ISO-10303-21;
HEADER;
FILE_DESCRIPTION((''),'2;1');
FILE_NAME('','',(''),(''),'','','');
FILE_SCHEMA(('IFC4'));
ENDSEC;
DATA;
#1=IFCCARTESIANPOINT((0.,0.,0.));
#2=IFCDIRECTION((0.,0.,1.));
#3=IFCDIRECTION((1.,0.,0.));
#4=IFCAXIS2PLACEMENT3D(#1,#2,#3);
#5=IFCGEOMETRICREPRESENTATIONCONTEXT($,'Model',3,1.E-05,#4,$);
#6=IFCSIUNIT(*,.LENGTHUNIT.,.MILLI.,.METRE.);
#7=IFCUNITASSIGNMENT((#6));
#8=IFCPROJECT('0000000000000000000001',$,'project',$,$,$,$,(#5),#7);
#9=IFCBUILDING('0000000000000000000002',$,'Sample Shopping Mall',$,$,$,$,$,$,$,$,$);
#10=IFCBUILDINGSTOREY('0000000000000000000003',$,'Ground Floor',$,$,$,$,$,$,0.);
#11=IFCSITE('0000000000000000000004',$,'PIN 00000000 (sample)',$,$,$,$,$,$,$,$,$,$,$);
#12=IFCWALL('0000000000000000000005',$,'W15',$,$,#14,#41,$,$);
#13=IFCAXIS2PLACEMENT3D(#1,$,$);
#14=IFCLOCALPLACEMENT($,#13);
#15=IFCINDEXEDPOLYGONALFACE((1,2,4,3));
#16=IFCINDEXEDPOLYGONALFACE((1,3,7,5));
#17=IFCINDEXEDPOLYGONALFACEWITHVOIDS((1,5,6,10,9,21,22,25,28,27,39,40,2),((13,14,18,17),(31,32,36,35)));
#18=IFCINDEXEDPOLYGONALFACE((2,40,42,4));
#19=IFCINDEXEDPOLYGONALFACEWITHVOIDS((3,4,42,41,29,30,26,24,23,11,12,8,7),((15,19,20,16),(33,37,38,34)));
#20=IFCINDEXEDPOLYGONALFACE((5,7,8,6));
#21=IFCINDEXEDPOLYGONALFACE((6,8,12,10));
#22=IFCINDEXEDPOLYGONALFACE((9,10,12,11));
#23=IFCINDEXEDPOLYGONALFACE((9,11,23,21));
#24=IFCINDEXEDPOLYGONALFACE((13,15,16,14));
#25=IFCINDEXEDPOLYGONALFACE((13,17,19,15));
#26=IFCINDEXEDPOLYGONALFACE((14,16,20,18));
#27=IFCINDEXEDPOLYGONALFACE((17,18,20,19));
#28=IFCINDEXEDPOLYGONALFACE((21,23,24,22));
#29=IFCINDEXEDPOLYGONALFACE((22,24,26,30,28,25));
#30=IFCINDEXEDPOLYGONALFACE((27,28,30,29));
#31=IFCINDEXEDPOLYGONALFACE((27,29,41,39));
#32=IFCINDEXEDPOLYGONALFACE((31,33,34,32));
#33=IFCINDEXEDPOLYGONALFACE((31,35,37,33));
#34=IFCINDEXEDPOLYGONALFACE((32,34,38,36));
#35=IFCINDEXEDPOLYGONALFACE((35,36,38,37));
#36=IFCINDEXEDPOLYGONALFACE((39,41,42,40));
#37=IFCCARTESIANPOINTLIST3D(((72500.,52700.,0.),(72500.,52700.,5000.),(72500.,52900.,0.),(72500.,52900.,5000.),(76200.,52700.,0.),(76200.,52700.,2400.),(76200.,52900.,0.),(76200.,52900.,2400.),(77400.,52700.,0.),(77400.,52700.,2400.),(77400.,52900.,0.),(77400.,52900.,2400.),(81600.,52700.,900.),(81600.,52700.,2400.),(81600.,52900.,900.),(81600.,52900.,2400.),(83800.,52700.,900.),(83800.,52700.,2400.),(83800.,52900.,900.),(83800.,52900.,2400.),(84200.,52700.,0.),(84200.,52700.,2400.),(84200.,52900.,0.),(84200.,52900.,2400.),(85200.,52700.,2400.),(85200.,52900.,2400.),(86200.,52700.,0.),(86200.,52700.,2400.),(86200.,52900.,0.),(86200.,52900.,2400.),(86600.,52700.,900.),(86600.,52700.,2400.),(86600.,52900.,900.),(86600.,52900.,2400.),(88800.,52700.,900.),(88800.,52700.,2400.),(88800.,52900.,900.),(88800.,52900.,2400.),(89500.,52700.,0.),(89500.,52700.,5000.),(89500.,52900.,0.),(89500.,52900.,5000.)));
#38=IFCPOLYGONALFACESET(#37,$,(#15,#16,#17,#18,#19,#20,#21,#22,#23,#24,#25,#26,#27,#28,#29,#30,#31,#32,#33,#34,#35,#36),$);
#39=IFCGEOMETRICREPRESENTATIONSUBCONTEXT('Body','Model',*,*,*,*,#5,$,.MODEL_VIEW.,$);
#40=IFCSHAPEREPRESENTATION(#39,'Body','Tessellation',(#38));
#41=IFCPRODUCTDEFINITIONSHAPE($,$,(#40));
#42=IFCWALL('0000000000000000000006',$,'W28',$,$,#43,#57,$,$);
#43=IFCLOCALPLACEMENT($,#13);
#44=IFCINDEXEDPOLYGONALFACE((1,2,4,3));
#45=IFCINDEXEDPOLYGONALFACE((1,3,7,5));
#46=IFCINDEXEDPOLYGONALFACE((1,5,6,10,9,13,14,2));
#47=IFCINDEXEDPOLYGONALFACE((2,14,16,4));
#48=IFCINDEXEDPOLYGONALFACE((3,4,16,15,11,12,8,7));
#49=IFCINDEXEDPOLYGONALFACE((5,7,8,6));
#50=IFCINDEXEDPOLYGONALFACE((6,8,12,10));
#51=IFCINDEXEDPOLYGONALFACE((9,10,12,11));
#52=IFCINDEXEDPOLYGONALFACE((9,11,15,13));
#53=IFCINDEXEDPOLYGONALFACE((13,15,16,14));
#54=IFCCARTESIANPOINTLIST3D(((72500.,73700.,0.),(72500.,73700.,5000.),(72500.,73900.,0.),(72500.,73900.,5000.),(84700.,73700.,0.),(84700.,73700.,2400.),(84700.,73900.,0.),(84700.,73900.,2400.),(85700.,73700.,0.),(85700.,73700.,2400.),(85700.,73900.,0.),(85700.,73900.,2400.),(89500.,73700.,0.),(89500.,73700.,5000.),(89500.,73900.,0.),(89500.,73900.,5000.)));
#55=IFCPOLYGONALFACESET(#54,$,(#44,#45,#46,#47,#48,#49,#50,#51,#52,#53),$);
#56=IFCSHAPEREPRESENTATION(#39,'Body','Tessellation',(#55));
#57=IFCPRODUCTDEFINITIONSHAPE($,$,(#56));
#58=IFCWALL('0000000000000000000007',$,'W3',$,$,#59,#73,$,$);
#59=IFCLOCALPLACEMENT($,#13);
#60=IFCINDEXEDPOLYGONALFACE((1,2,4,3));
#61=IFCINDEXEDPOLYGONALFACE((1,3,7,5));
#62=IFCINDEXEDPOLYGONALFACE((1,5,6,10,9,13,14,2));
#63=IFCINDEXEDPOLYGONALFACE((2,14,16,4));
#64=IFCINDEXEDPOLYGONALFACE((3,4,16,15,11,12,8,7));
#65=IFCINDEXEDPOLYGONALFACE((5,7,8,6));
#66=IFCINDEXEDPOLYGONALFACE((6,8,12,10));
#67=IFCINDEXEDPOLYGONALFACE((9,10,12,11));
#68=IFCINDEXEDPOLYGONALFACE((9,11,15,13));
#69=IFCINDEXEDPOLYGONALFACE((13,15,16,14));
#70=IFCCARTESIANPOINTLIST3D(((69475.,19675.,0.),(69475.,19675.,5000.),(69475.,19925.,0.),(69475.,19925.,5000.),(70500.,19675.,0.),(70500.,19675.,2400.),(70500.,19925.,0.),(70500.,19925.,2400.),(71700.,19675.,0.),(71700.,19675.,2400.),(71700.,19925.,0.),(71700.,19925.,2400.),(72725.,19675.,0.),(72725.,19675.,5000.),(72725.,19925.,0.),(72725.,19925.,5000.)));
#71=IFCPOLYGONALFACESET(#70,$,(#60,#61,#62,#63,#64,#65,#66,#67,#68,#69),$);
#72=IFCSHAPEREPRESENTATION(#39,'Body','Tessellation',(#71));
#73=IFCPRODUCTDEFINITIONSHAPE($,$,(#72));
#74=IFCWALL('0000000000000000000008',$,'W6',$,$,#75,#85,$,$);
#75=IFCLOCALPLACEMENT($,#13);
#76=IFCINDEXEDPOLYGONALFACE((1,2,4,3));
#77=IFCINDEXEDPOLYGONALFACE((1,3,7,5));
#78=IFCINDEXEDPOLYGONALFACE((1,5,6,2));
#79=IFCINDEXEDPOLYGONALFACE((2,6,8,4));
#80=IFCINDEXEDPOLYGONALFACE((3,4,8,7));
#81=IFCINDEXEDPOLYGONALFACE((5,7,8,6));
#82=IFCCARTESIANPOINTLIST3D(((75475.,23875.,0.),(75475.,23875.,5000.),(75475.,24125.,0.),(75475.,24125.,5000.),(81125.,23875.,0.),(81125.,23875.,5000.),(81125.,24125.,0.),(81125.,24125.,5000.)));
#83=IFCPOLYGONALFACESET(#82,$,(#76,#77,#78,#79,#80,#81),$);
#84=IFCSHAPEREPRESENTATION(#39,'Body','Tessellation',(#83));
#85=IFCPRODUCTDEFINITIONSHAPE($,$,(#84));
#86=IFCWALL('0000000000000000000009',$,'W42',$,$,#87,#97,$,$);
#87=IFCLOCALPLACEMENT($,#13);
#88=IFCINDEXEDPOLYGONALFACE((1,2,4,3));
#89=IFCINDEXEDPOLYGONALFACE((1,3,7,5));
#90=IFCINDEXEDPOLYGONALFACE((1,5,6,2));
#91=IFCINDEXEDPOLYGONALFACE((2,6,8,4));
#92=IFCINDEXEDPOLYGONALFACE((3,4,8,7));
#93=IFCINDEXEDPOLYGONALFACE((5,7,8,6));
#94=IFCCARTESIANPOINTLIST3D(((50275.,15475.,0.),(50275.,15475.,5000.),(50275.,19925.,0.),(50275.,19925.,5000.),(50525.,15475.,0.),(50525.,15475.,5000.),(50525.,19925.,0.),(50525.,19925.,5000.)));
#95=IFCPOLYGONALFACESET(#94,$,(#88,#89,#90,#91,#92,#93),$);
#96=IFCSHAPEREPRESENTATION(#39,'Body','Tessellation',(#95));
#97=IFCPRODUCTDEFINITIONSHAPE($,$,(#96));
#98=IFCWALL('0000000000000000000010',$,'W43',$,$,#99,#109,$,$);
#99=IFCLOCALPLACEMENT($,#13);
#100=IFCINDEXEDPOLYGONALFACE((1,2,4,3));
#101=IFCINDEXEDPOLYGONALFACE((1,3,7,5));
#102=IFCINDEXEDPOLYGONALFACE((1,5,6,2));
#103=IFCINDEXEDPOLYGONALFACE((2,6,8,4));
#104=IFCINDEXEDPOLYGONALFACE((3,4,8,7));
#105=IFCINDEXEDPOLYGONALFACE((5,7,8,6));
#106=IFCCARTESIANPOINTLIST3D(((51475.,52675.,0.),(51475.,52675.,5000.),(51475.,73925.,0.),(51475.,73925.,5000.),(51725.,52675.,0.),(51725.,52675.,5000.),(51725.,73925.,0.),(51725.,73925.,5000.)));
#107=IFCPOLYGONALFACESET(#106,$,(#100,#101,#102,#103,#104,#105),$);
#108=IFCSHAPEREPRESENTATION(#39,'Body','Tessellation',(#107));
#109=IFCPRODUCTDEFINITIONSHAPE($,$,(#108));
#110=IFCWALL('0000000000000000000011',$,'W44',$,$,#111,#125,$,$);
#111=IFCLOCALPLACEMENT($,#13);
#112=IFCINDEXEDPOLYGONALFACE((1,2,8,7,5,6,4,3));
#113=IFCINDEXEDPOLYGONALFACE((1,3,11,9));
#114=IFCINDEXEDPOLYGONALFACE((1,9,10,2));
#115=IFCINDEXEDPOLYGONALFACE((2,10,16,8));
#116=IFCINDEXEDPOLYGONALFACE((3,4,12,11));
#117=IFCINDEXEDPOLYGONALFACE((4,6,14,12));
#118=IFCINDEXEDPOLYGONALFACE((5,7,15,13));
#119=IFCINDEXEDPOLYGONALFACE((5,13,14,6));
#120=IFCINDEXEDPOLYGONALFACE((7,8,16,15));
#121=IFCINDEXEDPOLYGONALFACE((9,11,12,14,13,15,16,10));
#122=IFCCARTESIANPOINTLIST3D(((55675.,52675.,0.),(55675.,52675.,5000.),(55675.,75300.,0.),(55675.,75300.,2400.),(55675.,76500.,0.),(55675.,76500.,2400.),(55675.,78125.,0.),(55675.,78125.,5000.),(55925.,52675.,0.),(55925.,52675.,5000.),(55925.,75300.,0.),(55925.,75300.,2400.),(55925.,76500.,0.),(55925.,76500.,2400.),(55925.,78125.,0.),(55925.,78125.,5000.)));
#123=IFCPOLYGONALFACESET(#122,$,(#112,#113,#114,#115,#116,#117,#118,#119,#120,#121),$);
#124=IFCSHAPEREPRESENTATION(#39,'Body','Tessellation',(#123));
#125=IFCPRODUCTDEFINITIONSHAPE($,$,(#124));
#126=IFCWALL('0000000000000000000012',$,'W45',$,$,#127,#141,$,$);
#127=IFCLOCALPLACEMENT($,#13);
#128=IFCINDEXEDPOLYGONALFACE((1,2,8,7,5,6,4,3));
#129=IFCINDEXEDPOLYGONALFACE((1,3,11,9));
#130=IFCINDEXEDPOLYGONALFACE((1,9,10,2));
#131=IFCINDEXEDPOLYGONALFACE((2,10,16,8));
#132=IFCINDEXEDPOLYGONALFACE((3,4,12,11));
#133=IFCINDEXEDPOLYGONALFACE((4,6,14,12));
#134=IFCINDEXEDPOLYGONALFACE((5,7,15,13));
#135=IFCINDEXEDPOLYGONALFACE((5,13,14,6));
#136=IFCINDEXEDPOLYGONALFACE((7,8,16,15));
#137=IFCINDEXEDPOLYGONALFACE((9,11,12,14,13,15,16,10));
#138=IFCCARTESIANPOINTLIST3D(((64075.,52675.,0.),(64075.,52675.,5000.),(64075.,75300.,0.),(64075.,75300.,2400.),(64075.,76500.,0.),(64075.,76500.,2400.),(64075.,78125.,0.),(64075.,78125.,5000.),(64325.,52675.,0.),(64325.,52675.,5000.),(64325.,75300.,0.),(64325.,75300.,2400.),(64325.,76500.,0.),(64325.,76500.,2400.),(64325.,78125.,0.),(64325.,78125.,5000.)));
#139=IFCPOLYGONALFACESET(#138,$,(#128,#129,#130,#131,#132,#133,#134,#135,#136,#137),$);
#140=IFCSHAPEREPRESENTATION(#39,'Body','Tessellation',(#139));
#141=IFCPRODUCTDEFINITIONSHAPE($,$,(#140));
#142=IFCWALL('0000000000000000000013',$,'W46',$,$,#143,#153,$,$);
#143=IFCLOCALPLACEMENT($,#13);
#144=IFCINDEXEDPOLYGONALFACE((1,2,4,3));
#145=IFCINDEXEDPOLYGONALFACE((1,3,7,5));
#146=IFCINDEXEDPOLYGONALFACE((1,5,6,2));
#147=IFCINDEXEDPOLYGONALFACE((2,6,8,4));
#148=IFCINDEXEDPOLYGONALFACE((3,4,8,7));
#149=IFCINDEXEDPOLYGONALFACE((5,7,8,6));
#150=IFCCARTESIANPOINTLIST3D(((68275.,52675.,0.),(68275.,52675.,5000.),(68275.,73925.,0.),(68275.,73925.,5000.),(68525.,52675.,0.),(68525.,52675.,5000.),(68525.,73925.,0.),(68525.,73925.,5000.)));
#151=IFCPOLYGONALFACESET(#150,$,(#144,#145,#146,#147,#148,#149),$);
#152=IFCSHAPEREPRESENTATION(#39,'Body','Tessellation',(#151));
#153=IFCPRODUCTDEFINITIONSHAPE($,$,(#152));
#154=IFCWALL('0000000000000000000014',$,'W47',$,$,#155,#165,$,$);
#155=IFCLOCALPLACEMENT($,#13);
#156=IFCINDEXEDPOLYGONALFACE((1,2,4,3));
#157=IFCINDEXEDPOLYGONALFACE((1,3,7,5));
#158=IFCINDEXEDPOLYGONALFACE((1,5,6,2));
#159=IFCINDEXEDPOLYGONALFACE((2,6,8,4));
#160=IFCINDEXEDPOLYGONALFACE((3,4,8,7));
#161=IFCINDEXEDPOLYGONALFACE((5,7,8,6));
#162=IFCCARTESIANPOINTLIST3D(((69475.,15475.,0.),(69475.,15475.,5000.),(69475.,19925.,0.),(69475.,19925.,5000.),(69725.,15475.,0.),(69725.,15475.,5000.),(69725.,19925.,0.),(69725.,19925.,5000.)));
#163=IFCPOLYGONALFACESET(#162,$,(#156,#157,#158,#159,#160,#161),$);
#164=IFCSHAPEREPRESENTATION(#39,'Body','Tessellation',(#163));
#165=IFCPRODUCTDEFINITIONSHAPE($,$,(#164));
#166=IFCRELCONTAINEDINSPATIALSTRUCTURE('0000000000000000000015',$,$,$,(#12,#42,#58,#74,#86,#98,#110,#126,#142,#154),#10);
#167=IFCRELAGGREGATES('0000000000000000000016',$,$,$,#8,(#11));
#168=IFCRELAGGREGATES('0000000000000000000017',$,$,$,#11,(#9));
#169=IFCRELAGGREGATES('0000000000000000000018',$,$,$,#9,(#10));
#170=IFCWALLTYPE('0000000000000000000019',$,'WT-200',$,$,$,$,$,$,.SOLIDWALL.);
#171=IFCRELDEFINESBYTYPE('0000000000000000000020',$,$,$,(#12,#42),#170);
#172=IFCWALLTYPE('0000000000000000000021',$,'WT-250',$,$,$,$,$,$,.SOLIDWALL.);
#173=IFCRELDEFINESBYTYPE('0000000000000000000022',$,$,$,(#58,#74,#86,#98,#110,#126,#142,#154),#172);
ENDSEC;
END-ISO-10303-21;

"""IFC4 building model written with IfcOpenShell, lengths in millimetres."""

from ifc_helpers import new_model, si_unit, frame, origin_with_axes, place, context, subcontext, project, spatial, indexed_curve, outline, extrude, type_object, element, save


model = new_model("IFC4")

# Units and contexts
model_context = context("Model", 3, precision=1e-05, world=origin_with_axes())
body_context = subcontext(model_context, "Body", "Model", "MODEL_VIEW")
ifc_project = project(units=[si_unit("LENGTHUNIT", "METRE", prefix="MILLI")], contexts=[model_context])

# Site, building, storey
site = spatial("IfcSite", under=ifc_project, Name="PIN 00000000 (sample)")
building = spatial("IfcBuilding", under=site, Name="Sample Shopping Mall")
storey = spatial("IfcBuildingStorey", under=building, Name="Ground Floor", Elevation=0.0)

# Wall, openings
wall_type_1 = type_object("IfcWallType", Name="WT-200", PredefinedType="SOLIDWALL")
wall_1_placement = place(None, frame((72500.0, 52700.0, 0.0), z_axis=(0.0, 0.0, 1.0), x_axis=(1.0, 0.0, 0.0)))
wall_1 = element("IfcWall", 1, at=wall_1_placement, inside=storey, type_object=wall_type_1, Name="W15", context=body_context, shape_type="SweptSolid", body=[
    extrude(outline(indexed_curve([(0.0, 0.0), (0.0, 200.0), (17000.0, 200.0), (17000.0, 0.0), (0.0, 0.0)], self_intersect=False)), origin_with_axes(), (0.0, 0.0, 1.0), 5000.0),
])
opening_1_placement = place(wall_1_placement, frame((3700.0, -100.0, 0.0), z_axis=(0.0, 0.0, 1.0), x_axis=(1.0, 0.0, 0.0)))
element("IfcOpeningElement", 2, at=opening_1_placement, cuts=wall_1, context=body_context, shape_type="SweptSolid", body=[
    extrude(outline(indexed_curve([(0.0, 0.0), (0.0, 400.0), (1200.0, 400.0), (1200.0, 0.0), (0.0, 0.0)], self_intersect=False)), origin_with_axes(), (0.0, 0.0, 1.0), 2400.0),
])
opening_2_placement = place(wall_1_placement, frame((11700.0, -100.0, 0.0), z_axis=(0.0, 0.0, 1.0), x_axis=(1.0, 0.0, 0.0)))
element("IfcOpeningElement", 3, at=opening_2_placement, cuts=wall_1, context=body_context, shape_type="SweptSolid", body=[
    extrude(outline(indexed_curve([(0.0, 0.0), (0.0, 400.0), (1000.0, 400.0), (1000.0, 0.0), (0.0, 0.0)], self_intersect=False)), origin_with_axes(), (0.0, 0.0, 1.0), 2400.0),
])
opening_3_placement = place(wall_1_placement, frame((12700.0, -100.0, 0.0), z_axis=(0.0, 0.0, 1.0), x_axis=(1.0, 0.0, 0.0)))
element("IfcOpeningElement", 4, at=opening_3_placement, cuts=wall_1, context=body_context, shape_type="SweptSolid", body=[
    extrude(outline(indexed_curve([(0.0, 0.0), (0.0, 400.0), (1000.0, 400.0), (1000.0, 0.0), (0.0, 0.0)], self_intersect=False)), origin_with_axes(), (0.0, 0.0, 1.0), 2400.0),
])
opening_4_placement = place(wall_1_placement, frame((9100.0, -100.0, 900.0), z_axis=(0.0, 0.0, 1.0), x_axis=(1.0, 0.0, 0.0)))
element("IfcOpeningElement", 5, at=opening_4_placement, cuts=wall_1, context=body_context, shape_type="SweptSolid", body=[
    extrude(outline(indexed_curve([(0.0, 0.0), (0.0, 400.0), (2200.0, 400.0), (2200.0, 0.0), (0.0, 0.0)], self_intersect=False)), origin_with_axes(), (0.0, 0.0, 1.0), 1500.0),
])
opening_5_placement = place(wall_1_placement, frame((14100.0, -100.0, 900.0), z_axis=(0.0, 0.0, 1.0), x_axis=(1.0, 0.0, 0.0)))
element("IfcOpeningElement", 6, at=opening_5_placement, cuts=wall_1, context=body_context, shape_type="SweptSolid", body=[
    extrude(outline(indexed_curve([(0.0, 0.0), (0.0, 400.0), (2200.0, 400.0), (2200.0, 0.0), (0.0, 0.0)], self_intersect=False)), origin_with_axes(), (0.0, 0.0, 1.0), 1500.0),
])

# Walls, openings
wall_2_placement = place(None, frame((72500.0, 73700.0, 0.0), z_axis=(0.0, 0.0, 1.0), x_axis=(1.0, 0.0, 0.0)))
wall_2 = element("IfcWall", 7, at=wall_2_placement, inside=storey, type_object=wall_type_1, Name="W28", context=body_context, shape_type="SweptSolid", body=[
    extrude(outline(indexed_curve([(0.0, 0.0), (0.0, 200.0), (17000.0, 200.0), (17000.0, 0.0), (0.0, 0.0)], self_intersect=False)), origin_with_axes(), (0.0, 0.0, 1.0), 5000.0),
])
opening_6_placement = place(wall_2_placement, frame((12200.0, -100.0, 0.0), z_axis=(0.0, 0.0, 1.0), x_axis=(1.0, 0.0, 0.0)))
element("IfcOpeningElement", 8, at=opening_6_placement, cuts=wall_2, context=body_context, shape_type="SweptSolid", body=[
    extrude(outline(indexed_curve([(0.0, 0.0), (0.0, 400.0), (1000.0, 400.0), (1000.0, 0.0), (0.0, 0.0)], self_intersect=False)), origin_with_axes(), (0.0, 0.0, 1.0), 2400.0),
])
wall_type_2 = type_object("IfcWallType", Name="WT-250", PredefinedType="SOLIDWALL")
wall_3_placement = place(None, frame((69475.0, 19675.0, 0.0), z_axis=(0.0, 0.0, 1.0), x_axis=(1.0, 0.0, 0.0)))
wall_3 = element("IfcWall", 9, at=wall_3_placement, inside=storey, type_object=wall_type_2, Name="W3", context=body_context, shape_type="SweptSolid", body=[
    extrude(outline(indexed_curve([(0.0, 0.0), (0.0, 250.0), (3250.0, 250.0), (3250.0, 0.0), (0.0, 0.0)], self_intersect=False)), origin_with_axes(), (0.0, 0.0, 1.0), 5000.0),
])
opening_7_placement = place(wall_3_placement, frame((1025.0, -100.0, 0.0), z_axis=(0.0, 0.0, 1.0), x_axis=(1.0, 0.0, 0.0)))
element("IfcOpeningElement", 10, at=opening_7_placement, cuts=wall_3, context=body_context, shape_type="SweptSolid", body=[
    extrude(outline(indexed_curve([(0.0, 0.0), (0.0, 450.0), (1200.0, 450.0), (1200.0, 0.0), (0.0, 0.0)], self_intersect=False)), origin_with_axes(), (0.0, 0.0, 1.0), 2400.0),
])

# Wall
wall_4_placement = place(None, frame((75475.0, 23875.0, 0.0), z_axis=(0.0, 0.0, 1.0), x_axis=(1.0, 0.0, 0.0)))
element("IfcWall", 11, at=wall_4_placement, inside=storey, type_object=wall_type_2, Name="W6", context=body_context, shape_type="SweptSolid", body=[
    extrude(outline(indexed_curve([(0.0, 0.0), (0.0, 250.0), (5650.0, 250.0), (5650.0, 0.0), (0.0, 0.0)], self_intersect=False)), origin_with_axes(), (0.0, 0.0, 1.0), 5000.0),
])

# Walls
wall_5_placement = place(None, frame((50525.0, 15475.0, 0.0), z_axis=(0.0, 0.0, 1.0), x_axis=(0.0, 1.0, 0.0)))
element("IfcWall", 12, at=wall_5_placement, inside=storey, type_object=wall_type_2, Name="W42", context=body_context, shape_type="SweptSolid", body=[
    extrude(outline(indexed_curve([(0.0, 0.0), (0.0, 250.0), (4450.0, 250.0), (4450.0, 0.0), (0.0, 0.0)], self_intersect=False)), origin_with_axes(), (0.0, 0.0, 1.0), 5000.0),
])
wall_6_placement = place(None, frame((51725.0, 52675.0, 0.0), z_axis=(0.0, 0.0, 1.0), x_axis=(0.0, 1.0, 0.0)))
element("IfcWall", 13, at=wall_6_placement, inside=storey, type_object=wall_type_2, Name="W43", context=body_context, shape_type="SweptSolid", body=[
    extrude(outline(indexed_curve([(0.0, 0.0), (0.0, 250.0), (21250.0, 250.0), (21250.0, 0.0), (0.0, 0.0)], self_intersect=False)), origin_with_axes(), (0.0, 0.0, 1.0), 5000.0),
])

# Walls, openings
wall_7_placement = place(None, frame((55925.0, 52675.0, 0.0), z_axis=(0.0, 0.0, 1.0), x_axis=(0.0, 1.0, 0.0)))
wall_7 = element("IfcWall", 14, at=wall_7_placement, inside=storey, type_object=wall_type_2, Name="W44", context=body_context, shape_type="SweptSolid", body=[
    extrude(outline(indexed_curve([(0.0, 0.0), (0.0, 250.0), (25450.0, 250.0), (25450.0, 0.0), (0.0, 0.0)], self_intersect=False)), origin_with_axes(), (0.0, 0.0, 1.0), 5000.0),
])
opening_8_placement = place(wall_7_placement, frame((22625.0, -100.0, 0.0), z_axis=(0.0, 0.0, 1.0), x_axis=(1.0, 0.0, 0.0)))
element("IfcOpeningElement", 15, at=opening_8_placement, cuts=wall_7, context=body_context, shape_type="SweptSolid", body=[
    extrude(outline(indexed_curve([(0.0, 0.0), (0.0, 450.0), (1200.0, 450.0), (1200.0, 0.0), (0.0, 0.0)], self_intersect=False)), origin_with_axes(), (0.0, 0.0, 1.0), 2400.0),
])
wall_8_placement = place(None, frame((64325.0, 52675.0, 0.0), z_axis=(0.0, 0.0, 1.0), x_axis=(0.0, 1.0, 0.0)))
wall_8 = element("IfcWall", 16, at=wall_8_placement, inside=storey, type_object=wall_type_2, Name="W45", context=body_context, shape_type="SweptSolid", body=[
    extrude(outline(indexed_curve([(0.0, 0.0), (0.0, 250.0), (25450.0, 250.0), (25450.0, 0.0), (0.0, 0.0)], self_intersect=False)), origin_with_axes(), (0.0, 0.0, 1.0), 5000.0),
])
opening_9_placement = place(wall_8_placement, frame((22625.0, -100.0, 0.0), z_axis=(0.0, 0.0, 1.0), x_axis=(1.0, 0.0, 0.0)))
element("IfcOpeningElement", 17, at=opening_9_placement, cuts=wall_8, context=body_context, shape_type="SweptSolid", body=[
    extrude(outline(indexed_curve([(0.0, 0.0), (0.0, 450.0), (1200.0, 450.0), (1200.0, 0.0), (0.0, 0.0)], self_intersect=False)), origin_with_axes(), (0.0, 0.0, 1.0), 2400.0),
])

# Walls
wall_9_placement = place(None, frame((68525.0, 52675.0, 0.0), z_axis=(0.0, 0.0, 1.0), x_axis=(0.0, 1.0, 0.0)))
element("IfcWall", 18, at=wall_9_placement, inside=storey, type_object=wall_type_2, Name="W46", context=body_context, shape_type="SweptSolid", body=[
    extrude(outline(indexed_curve([(0.0, 0.0), (0.0, 250.0), (21250.0, 250.0), (21250.0, 0.0), (0.0, 0.0)], self_intersect=False)), origin_with_axes(), (0.0, 0.0, 1.0), 5000.0),
])
wall_10_placement = place(None, frame((69725.0, 15475.0, 0.0), z_axis=(0.0, 0.0, 1.0), x_axis=(0.0, 1.0, 0.0)))
element("IfcWall", 19, at=wall_10_placement, inside=storey, type_object=wall_type_2, Name="W47", context=body_context, shape_type="SweptSolid", body=[
    extrude(outline(indexed_curve([(0.0, 0.0), (0.0, 250.0), (4450.0, 250.0), (4450.0, 0.0), (0.0, 0.0)], self_intersect=False)), origin_with_axes(), (0.0, 0.0, 1.0), 5000.0),
])

save(model, "model.ifc")
